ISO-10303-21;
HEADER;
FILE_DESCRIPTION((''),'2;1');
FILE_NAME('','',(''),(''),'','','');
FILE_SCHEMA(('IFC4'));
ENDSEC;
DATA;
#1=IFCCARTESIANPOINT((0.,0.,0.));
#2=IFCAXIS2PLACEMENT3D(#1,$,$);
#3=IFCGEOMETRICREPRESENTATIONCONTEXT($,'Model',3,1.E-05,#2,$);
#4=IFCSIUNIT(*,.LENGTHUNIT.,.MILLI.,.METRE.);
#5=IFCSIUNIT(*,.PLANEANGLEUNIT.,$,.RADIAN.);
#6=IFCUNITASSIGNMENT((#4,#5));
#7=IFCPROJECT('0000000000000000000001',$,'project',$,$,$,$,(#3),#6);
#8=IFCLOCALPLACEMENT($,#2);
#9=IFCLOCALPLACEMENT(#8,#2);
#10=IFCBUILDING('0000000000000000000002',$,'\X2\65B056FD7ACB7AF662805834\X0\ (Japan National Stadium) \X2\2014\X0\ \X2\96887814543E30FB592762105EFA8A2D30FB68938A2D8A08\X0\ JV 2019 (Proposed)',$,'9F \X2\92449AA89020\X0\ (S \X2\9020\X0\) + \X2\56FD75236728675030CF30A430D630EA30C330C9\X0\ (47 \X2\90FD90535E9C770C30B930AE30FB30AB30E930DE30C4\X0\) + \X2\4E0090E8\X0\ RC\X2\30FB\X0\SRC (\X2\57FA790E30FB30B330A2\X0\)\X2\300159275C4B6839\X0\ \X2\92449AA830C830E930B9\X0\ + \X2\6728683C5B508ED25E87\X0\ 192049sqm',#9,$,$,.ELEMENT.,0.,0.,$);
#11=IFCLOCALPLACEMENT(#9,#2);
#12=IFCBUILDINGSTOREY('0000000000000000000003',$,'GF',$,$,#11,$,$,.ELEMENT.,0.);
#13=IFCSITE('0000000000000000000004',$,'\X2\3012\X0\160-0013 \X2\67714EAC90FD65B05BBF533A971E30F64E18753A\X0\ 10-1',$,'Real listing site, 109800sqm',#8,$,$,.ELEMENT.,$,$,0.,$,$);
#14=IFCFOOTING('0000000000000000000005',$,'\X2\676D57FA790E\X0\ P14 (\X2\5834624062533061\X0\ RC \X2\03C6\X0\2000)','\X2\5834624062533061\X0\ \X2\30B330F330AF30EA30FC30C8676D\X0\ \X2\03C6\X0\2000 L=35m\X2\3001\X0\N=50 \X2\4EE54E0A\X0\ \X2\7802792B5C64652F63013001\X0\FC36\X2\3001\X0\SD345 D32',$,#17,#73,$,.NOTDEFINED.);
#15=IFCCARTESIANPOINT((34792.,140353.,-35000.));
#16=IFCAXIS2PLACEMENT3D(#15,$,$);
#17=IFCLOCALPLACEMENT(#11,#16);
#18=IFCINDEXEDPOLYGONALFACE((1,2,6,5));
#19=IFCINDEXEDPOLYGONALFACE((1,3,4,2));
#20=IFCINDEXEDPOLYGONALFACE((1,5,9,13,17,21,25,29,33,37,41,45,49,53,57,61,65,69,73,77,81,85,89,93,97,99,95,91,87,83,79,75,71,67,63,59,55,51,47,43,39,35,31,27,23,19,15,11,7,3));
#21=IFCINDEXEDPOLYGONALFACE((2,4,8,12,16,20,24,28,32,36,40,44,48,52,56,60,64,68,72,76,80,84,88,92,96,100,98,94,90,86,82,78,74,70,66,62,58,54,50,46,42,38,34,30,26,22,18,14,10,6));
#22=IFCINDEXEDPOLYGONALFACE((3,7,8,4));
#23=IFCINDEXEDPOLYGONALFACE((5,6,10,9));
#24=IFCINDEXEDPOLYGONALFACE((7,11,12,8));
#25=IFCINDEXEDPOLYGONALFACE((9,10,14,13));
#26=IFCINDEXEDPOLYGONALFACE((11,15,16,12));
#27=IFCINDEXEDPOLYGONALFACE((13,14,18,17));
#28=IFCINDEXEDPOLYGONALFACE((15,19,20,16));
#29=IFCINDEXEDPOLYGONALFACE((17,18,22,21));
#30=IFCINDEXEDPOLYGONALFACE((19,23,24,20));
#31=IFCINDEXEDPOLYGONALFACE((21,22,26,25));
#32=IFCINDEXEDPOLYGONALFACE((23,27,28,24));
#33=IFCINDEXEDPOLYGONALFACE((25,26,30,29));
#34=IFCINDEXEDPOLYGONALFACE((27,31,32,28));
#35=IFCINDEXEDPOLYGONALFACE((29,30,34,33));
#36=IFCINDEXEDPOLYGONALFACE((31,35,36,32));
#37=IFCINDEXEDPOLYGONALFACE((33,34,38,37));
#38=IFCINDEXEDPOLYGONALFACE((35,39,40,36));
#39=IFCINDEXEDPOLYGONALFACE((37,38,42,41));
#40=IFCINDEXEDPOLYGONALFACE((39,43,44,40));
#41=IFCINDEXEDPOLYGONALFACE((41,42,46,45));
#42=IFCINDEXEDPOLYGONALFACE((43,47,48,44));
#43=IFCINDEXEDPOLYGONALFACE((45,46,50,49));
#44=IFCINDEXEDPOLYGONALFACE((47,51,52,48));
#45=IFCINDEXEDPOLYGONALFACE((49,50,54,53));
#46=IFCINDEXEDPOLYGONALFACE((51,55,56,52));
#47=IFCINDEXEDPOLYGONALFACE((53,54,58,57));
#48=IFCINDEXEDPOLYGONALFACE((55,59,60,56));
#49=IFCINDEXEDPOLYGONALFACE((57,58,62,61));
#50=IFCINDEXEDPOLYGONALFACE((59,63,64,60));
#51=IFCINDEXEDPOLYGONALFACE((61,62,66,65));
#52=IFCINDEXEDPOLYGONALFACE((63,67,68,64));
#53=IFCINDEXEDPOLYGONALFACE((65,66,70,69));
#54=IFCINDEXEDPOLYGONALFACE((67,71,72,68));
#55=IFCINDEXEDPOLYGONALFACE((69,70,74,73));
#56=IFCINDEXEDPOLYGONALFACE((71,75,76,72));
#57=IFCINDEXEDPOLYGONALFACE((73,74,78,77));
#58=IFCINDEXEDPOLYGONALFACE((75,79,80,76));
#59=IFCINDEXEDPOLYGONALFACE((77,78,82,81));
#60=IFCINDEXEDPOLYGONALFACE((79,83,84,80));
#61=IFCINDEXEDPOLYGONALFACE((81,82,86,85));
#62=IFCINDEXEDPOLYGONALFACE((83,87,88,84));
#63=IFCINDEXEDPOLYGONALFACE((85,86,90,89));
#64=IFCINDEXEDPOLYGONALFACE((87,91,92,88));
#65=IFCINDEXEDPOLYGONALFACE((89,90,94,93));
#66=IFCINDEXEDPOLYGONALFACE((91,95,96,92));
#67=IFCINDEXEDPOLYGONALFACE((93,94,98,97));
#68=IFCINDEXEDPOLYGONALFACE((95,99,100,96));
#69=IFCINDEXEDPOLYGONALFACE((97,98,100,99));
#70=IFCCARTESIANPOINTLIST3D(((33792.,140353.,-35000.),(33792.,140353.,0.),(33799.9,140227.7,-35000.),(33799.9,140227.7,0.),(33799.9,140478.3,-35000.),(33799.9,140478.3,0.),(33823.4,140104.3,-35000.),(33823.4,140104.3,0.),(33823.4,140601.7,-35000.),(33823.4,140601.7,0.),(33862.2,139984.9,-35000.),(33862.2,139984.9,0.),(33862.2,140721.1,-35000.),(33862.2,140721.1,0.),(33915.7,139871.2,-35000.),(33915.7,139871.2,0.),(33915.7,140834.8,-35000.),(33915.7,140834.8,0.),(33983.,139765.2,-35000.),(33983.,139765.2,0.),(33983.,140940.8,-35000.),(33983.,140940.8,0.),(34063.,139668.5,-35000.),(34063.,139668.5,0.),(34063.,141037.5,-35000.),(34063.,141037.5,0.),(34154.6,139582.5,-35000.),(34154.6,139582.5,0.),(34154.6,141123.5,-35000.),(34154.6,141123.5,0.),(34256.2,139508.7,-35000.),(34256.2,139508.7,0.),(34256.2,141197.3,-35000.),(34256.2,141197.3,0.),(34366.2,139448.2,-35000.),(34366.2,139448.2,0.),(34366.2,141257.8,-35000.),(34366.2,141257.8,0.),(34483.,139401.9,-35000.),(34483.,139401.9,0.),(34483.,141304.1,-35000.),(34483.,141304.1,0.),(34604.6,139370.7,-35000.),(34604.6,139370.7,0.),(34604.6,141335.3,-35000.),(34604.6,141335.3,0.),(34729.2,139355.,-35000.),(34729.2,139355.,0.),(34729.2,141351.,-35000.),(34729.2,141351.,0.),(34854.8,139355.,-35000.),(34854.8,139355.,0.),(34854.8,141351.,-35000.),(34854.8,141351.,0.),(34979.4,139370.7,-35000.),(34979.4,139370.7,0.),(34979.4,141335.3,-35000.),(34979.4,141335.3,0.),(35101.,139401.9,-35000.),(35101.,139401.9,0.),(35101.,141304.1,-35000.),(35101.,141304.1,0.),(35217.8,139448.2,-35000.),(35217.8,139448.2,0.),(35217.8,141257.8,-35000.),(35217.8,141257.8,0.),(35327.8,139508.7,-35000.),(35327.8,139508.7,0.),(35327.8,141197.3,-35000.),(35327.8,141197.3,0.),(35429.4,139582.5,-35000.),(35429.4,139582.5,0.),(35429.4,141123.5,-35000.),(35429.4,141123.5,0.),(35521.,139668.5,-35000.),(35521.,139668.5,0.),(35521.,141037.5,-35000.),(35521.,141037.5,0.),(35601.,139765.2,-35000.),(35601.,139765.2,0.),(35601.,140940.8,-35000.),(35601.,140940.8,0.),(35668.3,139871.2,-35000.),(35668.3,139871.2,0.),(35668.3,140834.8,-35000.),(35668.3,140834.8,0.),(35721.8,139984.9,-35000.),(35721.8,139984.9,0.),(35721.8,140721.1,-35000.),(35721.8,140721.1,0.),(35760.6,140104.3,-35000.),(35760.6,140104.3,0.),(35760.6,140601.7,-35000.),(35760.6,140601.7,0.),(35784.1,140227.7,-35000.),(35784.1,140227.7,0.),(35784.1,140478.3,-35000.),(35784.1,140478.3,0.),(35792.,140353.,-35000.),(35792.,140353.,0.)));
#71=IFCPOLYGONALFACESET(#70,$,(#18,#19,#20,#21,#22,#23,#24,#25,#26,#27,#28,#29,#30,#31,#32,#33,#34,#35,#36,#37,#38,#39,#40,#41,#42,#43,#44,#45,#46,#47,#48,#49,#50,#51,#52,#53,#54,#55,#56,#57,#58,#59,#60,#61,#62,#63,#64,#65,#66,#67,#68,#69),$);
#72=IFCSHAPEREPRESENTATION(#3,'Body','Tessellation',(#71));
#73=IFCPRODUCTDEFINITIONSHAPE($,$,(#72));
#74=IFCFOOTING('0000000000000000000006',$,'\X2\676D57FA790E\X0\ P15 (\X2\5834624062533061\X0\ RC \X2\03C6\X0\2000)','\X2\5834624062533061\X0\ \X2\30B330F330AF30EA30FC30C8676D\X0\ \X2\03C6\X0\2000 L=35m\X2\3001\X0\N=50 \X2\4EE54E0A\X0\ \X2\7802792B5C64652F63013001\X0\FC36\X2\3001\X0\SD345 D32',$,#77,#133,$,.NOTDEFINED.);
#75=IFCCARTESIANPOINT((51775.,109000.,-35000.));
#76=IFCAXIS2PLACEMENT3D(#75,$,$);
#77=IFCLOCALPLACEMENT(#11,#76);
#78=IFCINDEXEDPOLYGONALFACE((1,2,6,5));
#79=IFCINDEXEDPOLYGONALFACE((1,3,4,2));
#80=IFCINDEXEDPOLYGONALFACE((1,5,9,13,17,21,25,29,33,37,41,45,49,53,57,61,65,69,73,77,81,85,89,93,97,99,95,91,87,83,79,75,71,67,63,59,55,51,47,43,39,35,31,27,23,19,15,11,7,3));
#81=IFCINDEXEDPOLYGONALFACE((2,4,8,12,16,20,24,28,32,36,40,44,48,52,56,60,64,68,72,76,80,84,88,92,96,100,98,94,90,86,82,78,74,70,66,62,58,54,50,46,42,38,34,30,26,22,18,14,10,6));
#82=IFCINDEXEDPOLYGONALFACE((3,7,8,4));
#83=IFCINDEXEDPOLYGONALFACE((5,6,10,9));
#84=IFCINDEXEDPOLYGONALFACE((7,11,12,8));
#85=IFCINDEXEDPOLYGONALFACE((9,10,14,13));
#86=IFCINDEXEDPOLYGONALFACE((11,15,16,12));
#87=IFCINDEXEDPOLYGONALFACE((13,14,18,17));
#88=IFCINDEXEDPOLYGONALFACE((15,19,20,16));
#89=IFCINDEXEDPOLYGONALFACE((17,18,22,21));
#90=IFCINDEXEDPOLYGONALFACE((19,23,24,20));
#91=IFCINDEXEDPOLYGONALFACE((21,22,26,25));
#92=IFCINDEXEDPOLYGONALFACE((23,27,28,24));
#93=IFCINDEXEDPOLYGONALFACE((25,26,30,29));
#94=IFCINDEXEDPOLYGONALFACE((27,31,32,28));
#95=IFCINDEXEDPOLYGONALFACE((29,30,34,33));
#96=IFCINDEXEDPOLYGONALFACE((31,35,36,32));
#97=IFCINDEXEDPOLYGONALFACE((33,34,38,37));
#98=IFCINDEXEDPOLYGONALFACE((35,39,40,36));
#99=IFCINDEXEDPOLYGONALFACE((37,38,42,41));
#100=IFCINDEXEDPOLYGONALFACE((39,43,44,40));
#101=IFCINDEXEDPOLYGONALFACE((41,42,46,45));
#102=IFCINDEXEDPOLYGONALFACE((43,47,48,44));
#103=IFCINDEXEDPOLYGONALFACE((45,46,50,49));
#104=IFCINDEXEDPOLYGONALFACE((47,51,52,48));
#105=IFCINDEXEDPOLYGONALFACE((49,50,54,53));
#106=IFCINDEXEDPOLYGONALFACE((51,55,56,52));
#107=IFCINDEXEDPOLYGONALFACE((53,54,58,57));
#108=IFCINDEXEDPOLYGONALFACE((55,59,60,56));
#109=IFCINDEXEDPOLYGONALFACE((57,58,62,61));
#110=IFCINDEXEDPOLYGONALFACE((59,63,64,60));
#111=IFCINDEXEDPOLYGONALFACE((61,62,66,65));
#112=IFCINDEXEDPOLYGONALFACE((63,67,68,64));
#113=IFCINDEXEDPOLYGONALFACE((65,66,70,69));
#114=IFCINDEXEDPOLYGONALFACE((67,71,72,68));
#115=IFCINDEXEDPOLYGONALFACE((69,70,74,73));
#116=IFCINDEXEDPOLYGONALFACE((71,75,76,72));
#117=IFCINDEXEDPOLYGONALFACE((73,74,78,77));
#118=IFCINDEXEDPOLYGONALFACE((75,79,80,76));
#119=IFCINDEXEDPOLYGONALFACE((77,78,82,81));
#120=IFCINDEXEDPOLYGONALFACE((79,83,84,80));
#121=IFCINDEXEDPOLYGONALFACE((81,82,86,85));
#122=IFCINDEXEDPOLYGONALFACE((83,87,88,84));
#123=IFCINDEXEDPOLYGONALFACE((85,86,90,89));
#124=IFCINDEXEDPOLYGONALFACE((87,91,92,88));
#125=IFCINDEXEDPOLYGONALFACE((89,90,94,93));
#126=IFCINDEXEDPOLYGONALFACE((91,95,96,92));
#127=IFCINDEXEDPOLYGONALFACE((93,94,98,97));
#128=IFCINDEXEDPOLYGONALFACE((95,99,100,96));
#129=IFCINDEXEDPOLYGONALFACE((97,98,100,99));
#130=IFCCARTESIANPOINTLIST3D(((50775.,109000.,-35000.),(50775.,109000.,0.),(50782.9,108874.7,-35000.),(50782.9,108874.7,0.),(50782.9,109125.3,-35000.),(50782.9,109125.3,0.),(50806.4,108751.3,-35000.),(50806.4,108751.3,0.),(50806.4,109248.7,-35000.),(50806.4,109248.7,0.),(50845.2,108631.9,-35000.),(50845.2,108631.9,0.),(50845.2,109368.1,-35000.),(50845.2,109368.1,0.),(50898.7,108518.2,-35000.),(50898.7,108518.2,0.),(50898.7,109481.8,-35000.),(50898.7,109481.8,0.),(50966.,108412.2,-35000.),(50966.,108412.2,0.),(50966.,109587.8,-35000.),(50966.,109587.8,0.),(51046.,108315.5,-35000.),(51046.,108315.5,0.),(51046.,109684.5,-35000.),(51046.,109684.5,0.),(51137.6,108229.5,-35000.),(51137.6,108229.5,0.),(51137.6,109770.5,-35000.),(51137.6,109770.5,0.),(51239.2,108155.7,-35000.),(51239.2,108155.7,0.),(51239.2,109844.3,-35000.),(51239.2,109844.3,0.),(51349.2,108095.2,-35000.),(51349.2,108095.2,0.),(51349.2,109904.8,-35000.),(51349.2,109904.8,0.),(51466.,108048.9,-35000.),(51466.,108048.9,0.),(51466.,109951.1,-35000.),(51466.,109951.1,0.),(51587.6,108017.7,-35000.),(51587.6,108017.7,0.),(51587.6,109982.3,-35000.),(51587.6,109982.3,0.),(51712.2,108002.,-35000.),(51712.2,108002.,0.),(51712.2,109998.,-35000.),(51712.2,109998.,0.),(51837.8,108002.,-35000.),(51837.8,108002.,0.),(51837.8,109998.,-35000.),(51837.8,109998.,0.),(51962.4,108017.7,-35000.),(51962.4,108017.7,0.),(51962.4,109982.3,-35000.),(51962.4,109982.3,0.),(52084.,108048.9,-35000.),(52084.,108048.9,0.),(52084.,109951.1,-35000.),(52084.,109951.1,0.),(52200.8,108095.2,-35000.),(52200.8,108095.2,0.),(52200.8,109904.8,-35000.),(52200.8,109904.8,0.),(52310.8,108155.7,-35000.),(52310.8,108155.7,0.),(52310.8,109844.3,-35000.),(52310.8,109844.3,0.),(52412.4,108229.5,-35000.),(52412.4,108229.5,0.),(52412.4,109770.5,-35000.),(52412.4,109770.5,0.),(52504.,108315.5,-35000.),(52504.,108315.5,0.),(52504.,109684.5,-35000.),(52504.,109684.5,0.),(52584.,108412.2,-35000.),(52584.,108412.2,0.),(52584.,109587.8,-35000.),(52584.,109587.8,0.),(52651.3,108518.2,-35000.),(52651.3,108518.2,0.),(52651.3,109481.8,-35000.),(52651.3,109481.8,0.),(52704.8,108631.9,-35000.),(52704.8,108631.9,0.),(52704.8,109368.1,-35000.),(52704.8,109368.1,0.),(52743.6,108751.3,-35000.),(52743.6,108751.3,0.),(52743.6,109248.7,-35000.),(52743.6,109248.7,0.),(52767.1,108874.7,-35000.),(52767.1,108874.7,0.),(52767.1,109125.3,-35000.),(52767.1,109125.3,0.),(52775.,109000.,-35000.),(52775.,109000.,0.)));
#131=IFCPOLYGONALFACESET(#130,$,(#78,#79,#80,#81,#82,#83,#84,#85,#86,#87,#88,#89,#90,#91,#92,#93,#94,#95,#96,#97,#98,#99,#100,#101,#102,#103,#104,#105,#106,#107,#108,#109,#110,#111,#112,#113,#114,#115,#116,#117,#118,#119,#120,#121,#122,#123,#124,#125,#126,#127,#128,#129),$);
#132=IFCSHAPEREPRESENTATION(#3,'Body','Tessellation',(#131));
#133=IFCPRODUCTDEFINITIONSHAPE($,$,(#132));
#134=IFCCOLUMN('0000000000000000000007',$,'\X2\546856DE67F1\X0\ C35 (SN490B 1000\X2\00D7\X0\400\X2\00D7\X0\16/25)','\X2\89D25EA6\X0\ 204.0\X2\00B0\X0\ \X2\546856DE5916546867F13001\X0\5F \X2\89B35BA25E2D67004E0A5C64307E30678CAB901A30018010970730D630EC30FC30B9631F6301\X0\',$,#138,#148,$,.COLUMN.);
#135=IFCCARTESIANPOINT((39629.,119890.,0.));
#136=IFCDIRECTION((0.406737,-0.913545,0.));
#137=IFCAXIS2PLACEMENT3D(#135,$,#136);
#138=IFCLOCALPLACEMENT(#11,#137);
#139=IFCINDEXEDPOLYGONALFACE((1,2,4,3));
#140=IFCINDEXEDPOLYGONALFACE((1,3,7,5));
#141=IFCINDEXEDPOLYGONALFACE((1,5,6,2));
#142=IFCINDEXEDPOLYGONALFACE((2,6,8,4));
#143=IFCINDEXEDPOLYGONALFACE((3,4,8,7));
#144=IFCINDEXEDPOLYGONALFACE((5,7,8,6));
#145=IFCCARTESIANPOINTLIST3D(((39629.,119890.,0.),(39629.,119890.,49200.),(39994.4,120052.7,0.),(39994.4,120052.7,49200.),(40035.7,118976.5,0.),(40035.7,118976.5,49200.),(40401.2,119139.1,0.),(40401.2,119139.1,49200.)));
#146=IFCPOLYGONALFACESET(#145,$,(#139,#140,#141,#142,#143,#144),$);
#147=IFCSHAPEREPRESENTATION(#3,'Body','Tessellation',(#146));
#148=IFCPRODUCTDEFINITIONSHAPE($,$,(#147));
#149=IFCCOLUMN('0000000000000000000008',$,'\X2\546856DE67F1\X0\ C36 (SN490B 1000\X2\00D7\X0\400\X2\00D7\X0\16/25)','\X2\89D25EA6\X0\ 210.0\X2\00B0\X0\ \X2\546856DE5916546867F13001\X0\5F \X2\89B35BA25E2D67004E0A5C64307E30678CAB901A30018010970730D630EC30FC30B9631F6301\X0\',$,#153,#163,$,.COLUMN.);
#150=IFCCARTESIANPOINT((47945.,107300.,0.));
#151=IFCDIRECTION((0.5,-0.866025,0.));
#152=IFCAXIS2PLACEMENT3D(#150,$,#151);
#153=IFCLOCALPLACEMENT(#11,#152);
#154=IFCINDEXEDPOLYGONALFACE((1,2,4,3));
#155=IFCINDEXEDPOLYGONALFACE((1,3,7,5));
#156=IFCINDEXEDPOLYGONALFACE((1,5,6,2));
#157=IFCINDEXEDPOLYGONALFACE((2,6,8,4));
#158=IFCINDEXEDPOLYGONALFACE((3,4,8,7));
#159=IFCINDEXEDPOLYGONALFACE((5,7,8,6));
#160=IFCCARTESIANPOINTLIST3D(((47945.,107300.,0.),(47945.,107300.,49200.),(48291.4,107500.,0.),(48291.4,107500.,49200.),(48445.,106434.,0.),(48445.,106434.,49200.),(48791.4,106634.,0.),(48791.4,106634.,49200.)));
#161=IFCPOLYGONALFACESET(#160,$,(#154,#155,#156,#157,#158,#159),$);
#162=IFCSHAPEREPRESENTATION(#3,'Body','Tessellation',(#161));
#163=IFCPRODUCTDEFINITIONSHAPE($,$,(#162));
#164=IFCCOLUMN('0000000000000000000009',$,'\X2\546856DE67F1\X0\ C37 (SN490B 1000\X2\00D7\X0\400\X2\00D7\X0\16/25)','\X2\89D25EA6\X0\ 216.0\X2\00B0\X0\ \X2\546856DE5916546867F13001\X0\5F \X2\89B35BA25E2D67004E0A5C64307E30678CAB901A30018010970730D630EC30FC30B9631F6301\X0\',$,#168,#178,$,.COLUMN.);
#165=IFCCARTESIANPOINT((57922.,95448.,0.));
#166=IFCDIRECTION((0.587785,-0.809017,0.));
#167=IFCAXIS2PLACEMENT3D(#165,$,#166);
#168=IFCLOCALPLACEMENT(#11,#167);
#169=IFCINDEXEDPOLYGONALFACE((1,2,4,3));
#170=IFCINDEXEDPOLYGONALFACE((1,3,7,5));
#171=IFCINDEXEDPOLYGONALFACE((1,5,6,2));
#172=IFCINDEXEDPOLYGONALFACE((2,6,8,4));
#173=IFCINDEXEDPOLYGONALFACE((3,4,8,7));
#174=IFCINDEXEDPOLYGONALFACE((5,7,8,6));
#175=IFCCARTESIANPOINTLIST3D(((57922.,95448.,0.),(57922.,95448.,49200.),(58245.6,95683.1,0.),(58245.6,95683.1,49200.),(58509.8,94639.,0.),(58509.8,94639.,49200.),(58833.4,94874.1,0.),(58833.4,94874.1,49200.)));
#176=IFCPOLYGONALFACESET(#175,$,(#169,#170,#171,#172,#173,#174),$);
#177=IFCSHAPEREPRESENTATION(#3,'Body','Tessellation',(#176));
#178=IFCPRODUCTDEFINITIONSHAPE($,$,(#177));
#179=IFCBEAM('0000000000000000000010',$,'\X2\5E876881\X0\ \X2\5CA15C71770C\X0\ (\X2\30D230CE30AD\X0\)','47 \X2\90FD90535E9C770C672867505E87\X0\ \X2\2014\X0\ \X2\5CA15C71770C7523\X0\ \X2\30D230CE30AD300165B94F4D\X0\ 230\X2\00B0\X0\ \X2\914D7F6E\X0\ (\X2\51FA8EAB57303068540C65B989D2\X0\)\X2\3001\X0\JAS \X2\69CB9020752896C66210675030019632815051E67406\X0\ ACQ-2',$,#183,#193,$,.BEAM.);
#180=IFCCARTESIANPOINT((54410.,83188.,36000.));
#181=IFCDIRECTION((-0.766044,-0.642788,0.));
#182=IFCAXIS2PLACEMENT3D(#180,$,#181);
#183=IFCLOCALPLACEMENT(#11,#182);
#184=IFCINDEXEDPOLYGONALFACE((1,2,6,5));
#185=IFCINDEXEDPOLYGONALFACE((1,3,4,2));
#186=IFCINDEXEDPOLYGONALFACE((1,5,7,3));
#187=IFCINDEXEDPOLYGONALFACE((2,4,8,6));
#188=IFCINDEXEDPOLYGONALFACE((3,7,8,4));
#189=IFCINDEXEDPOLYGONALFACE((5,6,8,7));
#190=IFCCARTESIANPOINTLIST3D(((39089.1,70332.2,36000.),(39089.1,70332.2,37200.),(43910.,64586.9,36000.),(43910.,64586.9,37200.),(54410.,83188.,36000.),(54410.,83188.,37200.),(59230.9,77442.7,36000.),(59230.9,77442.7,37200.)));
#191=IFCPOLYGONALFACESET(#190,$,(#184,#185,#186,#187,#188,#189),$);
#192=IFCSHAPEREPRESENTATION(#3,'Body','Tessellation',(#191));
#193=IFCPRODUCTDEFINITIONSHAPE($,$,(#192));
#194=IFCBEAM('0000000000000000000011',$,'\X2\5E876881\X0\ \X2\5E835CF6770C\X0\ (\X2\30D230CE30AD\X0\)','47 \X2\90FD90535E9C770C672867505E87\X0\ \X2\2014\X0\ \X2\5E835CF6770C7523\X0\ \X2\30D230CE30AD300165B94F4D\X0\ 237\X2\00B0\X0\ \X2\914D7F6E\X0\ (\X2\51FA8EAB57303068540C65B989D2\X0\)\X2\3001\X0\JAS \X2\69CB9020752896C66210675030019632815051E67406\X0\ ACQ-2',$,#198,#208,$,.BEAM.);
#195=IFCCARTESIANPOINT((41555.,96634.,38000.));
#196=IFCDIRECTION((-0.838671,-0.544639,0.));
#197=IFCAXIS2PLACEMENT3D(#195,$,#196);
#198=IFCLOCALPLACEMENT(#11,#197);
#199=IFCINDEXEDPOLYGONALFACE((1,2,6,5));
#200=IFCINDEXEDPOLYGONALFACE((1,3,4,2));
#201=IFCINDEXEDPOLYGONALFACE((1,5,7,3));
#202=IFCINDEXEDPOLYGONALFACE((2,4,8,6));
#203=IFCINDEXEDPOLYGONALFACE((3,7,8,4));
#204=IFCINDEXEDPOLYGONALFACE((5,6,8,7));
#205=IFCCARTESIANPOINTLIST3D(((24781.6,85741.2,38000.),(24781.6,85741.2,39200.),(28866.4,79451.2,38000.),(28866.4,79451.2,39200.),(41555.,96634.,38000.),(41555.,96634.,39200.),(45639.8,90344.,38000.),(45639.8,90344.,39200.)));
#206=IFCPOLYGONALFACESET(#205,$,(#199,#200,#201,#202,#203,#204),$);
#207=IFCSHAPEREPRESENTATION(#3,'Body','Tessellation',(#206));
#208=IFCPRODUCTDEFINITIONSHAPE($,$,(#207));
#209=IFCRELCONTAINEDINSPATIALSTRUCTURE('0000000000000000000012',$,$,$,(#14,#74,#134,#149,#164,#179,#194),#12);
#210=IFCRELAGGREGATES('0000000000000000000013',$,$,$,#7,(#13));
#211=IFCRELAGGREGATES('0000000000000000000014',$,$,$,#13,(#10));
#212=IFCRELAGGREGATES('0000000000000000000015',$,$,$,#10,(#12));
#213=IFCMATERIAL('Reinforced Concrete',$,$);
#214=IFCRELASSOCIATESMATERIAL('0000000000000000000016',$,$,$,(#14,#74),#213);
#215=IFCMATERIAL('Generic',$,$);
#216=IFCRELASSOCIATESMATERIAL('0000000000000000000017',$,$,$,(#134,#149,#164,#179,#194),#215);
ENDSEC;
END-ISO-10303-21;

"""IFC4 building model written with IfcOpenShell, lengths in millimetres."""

from ifc_helpers import new_model, si_unit, frame, frame_2d, origin, origin_2d, place, context, project, spatial, rectangle, circle, extrude, material, element, save


model = new_model("IFC4")

# Units and contexts
model_context = context("Model", 3, precision=1e-05, world=origin())
ifc_project = project(units=[si_unit("LENGTHUNIT", "METRE", prefix="MILLI"), si_unit("PLANEANGLEUNIT", "RADIAN")], contexts=[model_context])

# Site, building, storey
site_placement = place(None, origin())
site = spatial("IfcSite", under=ifc_project, at=site_placement, Name="〒160-0013 東京都新宿区霞ヶ丘町 10-1", ObjectType="Real listing site, 109800sqm", CompositionType="ELEMENT", RefElevation=0.0)
building_placement = place(site_placement, origin())
building = spatial("IfcBuilding", under=site, at=building_placement, Name="新国立競技場 (Japan National Stadium) — 隈研吾・大成建設・梓設計 JV 2019 (Proposed)", ObjectType="9F 鉄骨造 (S 造) + 国産木材ハイブリッド (47 都道府県スギ・カラマツ) + 一部 RC・SRC (基礎・コア)、大屋根 鉄骨トラス + 木格子軒庇 192049sqm", CompositionType="ELEMENT", ElevationOfRefHeight=0.0, ElevationOfTerrain=0.0)
storey_placement = place(building_placement, origin())
storey = spatial("IfcBuildingStorey", under=building, at=storey_placement, Name="GF", CompositionType="ELEMENT", Elevation=0.0)

# Footings
ifc_material_1 = material(Name="Reinforced Concrete")
footing_1_placement = place(storey_placement, frame((34792.0, 140353.0, -35000.0)))
element("IfcFooting", 1, at=footing_1_placement, inside=storey, material=ifc_material_1, Name="杭基礎 P14 (場所打ち RC φ2000)", Description="場所打ち コンクリート杭 φ2000 L=35m、N=50 以上 砂礫層支持、FC36、SD345 D32", PredefinedType="NOTDEFINED", context=model_context, shape_type="SweptSolid", body=[
    extrude(circle(Radius=1000.0, at=origin_2d()), frame((34792.0, 140353.0, -35000.0)), (0.0, 0.0, 1.0), 35000.0),
])
footing_2_placement = place(storey_placement, frame((51775.0, 109000.0, -35000.0)))
element("IfcFooting", 2, at=footing_2_placement, inside=storey, material=ifc_material_1, Name="杭基礎 P15 (場所打ち RC φ2000)", Description="場所打ち コンクリート杭 φ2000 L=35m、N=50 以上 砂礫層支持、FC36、SD345 D32", PredefinedType="NOTDEFINED", context=model_context, shape_type="SweptSolid", body=[
    extrude(circle(Radius=1000.0, at=origin_2d()), frame((51775.0, 109000.0, -35000.0)), (0.0, 0.0, 1.0), 35000.0),
])

# Columns
ifc_material_2 = material(Name="Generic")
column_1_placement = place(storey_placement, frame((39629.0, 119890.0, 0.0), x_axis=(0.406737, -0.913545, 0.0)))
element("IfcColumn", 3, at=column_1_placement, inside=storey, material=ifc_material_2, Name="周回柱 C35 (SN490B 1000×400×16/25)", Description="角度 204.0° 周回外周柱、5F 観客席最上層まで貫通、耐震ブレース挟持", PredefinedType="COLUMN", context=model_context, shape_type="SweptSolid", body=[
    extrude(rectangle(XDim=1000.0, YDim=400.0, at=frame_2d((500.0, 200.0))), frame((39629.0, 119890.0, 0.0), x_axis=(0.406737, -0.913545, 0.0)), (0.0, 0.0, 1.0), 49200.0),
])
column_2_placement = place(storey_placement, frame((47945.0, 107300.0, 0.0), x_axis=(0.5, -0.866025, 0.0)))
element("IfcColumn", 4, at=column_2_placement, inside=storey, material=ifc_material_2, Name="周回柱 C36 (SN490B 1000×400×16/25)", Description="角度 210.0° 周回外周柱、5F 観客席最上層まで貫通、耐震ブレース挟持", PredefinedType="COLUMN", context=model_context, shape_type="SweptSolid", body=[
    extrude(rectangle(XDim=1000.0, YDim=400.0, at=frame_2d((500.0, 200.0))), frame((47945.0, 107300.0, 0.0), x_axis=(0.5, -0.866025, 0.0)), (0.0, 0.0, 1.0), 49200.0),
])
column_3_placement = place(storey_placement, frame((57922.0, 95448.0, 0.0), x_axis=(0.587785, -0.809017, 0.0)))
element("IfcColumn", 5, at=column_3_placement, inside=storey, material=ifc_material_2, Name="周回柱 C37 (SN490B 1000×400×16/25)", Description="角度 216.0° 周回外周柱、5F 観客席最上層まで貫通、耐震ブレース挟持", PredefinedType="COLUMN", context=model_context, shape_type="SweptSolid", body=[
    extrude(rectangle(XDim=1000.0, YDim=400.0, at=frame_2d((500.0, 200.0))), frame((57922.0, 95448.0, 0.0), x_axis=(0.587785, -0.809017, 0.0)), (0.0, 0.0, 1.0), 49200.0),
])

# Beams
beam_1_placement = place(storey_placement, frame((54410.0, 83188.0, 36000.0), x_axis=(-0.766044, -0.642788, 0.0)))
element("IfcBeam", 6, at=beam_1_placement, inside=storey, material=ifc_material_2, Name="庇梁 岡山県 (ヒノキ)", Description="47 都道府県木材庇 — 岡山県産 ヒノキ、方位 230° 配置 (出身地と同方角)、JAS 構造用集成材、防腐処理 ACQ-2", PredefinedType="BEAM", context=model_context, shape_type="SweptSolid", body=[
    extrude(rectangle(XDim=20000.0, YDim=7500.0, at=frame_2d((10000.0, 3750.0))), frame((54410.0, 83188.0, 36000.0), x_axis=(-0.766044, -0.642788, 0.0)), (0.0, 0.0, 1.0), 1200.0),
])
beam_2_placement = place(storey_placement, frame((41555.0, 96634.0, 38000.0), x_axis=(-0.838671, -0.544639, 0.0)))
element("IfcBeam", 7, at=beam_2_placement, inside=storey, material=ifc_material_2, Name="庇梁 広島県 (ヒノキ)", Description="47 都道府県木材庇 — 広島県産 ヒノキ、方位 237° 配置 (出身地と同方角)、JAS 構造用集成材、防腐処理 ACQ-2", PredefinedType="BEAM", context=model_context, shape_type="SweptSolid", body=[
    extrude(rectangle(XDim=20000.0, YDim=7500.0, at=frame_2d((10000.0, 3750.0))), frame((41555.0, 96634.0, 38000.0), x_axis=(-0.838671, -0.544639, 0.0)), (0.0, 0.0, 1.0), 1200.0),
])

save(model, "model.ifc")
